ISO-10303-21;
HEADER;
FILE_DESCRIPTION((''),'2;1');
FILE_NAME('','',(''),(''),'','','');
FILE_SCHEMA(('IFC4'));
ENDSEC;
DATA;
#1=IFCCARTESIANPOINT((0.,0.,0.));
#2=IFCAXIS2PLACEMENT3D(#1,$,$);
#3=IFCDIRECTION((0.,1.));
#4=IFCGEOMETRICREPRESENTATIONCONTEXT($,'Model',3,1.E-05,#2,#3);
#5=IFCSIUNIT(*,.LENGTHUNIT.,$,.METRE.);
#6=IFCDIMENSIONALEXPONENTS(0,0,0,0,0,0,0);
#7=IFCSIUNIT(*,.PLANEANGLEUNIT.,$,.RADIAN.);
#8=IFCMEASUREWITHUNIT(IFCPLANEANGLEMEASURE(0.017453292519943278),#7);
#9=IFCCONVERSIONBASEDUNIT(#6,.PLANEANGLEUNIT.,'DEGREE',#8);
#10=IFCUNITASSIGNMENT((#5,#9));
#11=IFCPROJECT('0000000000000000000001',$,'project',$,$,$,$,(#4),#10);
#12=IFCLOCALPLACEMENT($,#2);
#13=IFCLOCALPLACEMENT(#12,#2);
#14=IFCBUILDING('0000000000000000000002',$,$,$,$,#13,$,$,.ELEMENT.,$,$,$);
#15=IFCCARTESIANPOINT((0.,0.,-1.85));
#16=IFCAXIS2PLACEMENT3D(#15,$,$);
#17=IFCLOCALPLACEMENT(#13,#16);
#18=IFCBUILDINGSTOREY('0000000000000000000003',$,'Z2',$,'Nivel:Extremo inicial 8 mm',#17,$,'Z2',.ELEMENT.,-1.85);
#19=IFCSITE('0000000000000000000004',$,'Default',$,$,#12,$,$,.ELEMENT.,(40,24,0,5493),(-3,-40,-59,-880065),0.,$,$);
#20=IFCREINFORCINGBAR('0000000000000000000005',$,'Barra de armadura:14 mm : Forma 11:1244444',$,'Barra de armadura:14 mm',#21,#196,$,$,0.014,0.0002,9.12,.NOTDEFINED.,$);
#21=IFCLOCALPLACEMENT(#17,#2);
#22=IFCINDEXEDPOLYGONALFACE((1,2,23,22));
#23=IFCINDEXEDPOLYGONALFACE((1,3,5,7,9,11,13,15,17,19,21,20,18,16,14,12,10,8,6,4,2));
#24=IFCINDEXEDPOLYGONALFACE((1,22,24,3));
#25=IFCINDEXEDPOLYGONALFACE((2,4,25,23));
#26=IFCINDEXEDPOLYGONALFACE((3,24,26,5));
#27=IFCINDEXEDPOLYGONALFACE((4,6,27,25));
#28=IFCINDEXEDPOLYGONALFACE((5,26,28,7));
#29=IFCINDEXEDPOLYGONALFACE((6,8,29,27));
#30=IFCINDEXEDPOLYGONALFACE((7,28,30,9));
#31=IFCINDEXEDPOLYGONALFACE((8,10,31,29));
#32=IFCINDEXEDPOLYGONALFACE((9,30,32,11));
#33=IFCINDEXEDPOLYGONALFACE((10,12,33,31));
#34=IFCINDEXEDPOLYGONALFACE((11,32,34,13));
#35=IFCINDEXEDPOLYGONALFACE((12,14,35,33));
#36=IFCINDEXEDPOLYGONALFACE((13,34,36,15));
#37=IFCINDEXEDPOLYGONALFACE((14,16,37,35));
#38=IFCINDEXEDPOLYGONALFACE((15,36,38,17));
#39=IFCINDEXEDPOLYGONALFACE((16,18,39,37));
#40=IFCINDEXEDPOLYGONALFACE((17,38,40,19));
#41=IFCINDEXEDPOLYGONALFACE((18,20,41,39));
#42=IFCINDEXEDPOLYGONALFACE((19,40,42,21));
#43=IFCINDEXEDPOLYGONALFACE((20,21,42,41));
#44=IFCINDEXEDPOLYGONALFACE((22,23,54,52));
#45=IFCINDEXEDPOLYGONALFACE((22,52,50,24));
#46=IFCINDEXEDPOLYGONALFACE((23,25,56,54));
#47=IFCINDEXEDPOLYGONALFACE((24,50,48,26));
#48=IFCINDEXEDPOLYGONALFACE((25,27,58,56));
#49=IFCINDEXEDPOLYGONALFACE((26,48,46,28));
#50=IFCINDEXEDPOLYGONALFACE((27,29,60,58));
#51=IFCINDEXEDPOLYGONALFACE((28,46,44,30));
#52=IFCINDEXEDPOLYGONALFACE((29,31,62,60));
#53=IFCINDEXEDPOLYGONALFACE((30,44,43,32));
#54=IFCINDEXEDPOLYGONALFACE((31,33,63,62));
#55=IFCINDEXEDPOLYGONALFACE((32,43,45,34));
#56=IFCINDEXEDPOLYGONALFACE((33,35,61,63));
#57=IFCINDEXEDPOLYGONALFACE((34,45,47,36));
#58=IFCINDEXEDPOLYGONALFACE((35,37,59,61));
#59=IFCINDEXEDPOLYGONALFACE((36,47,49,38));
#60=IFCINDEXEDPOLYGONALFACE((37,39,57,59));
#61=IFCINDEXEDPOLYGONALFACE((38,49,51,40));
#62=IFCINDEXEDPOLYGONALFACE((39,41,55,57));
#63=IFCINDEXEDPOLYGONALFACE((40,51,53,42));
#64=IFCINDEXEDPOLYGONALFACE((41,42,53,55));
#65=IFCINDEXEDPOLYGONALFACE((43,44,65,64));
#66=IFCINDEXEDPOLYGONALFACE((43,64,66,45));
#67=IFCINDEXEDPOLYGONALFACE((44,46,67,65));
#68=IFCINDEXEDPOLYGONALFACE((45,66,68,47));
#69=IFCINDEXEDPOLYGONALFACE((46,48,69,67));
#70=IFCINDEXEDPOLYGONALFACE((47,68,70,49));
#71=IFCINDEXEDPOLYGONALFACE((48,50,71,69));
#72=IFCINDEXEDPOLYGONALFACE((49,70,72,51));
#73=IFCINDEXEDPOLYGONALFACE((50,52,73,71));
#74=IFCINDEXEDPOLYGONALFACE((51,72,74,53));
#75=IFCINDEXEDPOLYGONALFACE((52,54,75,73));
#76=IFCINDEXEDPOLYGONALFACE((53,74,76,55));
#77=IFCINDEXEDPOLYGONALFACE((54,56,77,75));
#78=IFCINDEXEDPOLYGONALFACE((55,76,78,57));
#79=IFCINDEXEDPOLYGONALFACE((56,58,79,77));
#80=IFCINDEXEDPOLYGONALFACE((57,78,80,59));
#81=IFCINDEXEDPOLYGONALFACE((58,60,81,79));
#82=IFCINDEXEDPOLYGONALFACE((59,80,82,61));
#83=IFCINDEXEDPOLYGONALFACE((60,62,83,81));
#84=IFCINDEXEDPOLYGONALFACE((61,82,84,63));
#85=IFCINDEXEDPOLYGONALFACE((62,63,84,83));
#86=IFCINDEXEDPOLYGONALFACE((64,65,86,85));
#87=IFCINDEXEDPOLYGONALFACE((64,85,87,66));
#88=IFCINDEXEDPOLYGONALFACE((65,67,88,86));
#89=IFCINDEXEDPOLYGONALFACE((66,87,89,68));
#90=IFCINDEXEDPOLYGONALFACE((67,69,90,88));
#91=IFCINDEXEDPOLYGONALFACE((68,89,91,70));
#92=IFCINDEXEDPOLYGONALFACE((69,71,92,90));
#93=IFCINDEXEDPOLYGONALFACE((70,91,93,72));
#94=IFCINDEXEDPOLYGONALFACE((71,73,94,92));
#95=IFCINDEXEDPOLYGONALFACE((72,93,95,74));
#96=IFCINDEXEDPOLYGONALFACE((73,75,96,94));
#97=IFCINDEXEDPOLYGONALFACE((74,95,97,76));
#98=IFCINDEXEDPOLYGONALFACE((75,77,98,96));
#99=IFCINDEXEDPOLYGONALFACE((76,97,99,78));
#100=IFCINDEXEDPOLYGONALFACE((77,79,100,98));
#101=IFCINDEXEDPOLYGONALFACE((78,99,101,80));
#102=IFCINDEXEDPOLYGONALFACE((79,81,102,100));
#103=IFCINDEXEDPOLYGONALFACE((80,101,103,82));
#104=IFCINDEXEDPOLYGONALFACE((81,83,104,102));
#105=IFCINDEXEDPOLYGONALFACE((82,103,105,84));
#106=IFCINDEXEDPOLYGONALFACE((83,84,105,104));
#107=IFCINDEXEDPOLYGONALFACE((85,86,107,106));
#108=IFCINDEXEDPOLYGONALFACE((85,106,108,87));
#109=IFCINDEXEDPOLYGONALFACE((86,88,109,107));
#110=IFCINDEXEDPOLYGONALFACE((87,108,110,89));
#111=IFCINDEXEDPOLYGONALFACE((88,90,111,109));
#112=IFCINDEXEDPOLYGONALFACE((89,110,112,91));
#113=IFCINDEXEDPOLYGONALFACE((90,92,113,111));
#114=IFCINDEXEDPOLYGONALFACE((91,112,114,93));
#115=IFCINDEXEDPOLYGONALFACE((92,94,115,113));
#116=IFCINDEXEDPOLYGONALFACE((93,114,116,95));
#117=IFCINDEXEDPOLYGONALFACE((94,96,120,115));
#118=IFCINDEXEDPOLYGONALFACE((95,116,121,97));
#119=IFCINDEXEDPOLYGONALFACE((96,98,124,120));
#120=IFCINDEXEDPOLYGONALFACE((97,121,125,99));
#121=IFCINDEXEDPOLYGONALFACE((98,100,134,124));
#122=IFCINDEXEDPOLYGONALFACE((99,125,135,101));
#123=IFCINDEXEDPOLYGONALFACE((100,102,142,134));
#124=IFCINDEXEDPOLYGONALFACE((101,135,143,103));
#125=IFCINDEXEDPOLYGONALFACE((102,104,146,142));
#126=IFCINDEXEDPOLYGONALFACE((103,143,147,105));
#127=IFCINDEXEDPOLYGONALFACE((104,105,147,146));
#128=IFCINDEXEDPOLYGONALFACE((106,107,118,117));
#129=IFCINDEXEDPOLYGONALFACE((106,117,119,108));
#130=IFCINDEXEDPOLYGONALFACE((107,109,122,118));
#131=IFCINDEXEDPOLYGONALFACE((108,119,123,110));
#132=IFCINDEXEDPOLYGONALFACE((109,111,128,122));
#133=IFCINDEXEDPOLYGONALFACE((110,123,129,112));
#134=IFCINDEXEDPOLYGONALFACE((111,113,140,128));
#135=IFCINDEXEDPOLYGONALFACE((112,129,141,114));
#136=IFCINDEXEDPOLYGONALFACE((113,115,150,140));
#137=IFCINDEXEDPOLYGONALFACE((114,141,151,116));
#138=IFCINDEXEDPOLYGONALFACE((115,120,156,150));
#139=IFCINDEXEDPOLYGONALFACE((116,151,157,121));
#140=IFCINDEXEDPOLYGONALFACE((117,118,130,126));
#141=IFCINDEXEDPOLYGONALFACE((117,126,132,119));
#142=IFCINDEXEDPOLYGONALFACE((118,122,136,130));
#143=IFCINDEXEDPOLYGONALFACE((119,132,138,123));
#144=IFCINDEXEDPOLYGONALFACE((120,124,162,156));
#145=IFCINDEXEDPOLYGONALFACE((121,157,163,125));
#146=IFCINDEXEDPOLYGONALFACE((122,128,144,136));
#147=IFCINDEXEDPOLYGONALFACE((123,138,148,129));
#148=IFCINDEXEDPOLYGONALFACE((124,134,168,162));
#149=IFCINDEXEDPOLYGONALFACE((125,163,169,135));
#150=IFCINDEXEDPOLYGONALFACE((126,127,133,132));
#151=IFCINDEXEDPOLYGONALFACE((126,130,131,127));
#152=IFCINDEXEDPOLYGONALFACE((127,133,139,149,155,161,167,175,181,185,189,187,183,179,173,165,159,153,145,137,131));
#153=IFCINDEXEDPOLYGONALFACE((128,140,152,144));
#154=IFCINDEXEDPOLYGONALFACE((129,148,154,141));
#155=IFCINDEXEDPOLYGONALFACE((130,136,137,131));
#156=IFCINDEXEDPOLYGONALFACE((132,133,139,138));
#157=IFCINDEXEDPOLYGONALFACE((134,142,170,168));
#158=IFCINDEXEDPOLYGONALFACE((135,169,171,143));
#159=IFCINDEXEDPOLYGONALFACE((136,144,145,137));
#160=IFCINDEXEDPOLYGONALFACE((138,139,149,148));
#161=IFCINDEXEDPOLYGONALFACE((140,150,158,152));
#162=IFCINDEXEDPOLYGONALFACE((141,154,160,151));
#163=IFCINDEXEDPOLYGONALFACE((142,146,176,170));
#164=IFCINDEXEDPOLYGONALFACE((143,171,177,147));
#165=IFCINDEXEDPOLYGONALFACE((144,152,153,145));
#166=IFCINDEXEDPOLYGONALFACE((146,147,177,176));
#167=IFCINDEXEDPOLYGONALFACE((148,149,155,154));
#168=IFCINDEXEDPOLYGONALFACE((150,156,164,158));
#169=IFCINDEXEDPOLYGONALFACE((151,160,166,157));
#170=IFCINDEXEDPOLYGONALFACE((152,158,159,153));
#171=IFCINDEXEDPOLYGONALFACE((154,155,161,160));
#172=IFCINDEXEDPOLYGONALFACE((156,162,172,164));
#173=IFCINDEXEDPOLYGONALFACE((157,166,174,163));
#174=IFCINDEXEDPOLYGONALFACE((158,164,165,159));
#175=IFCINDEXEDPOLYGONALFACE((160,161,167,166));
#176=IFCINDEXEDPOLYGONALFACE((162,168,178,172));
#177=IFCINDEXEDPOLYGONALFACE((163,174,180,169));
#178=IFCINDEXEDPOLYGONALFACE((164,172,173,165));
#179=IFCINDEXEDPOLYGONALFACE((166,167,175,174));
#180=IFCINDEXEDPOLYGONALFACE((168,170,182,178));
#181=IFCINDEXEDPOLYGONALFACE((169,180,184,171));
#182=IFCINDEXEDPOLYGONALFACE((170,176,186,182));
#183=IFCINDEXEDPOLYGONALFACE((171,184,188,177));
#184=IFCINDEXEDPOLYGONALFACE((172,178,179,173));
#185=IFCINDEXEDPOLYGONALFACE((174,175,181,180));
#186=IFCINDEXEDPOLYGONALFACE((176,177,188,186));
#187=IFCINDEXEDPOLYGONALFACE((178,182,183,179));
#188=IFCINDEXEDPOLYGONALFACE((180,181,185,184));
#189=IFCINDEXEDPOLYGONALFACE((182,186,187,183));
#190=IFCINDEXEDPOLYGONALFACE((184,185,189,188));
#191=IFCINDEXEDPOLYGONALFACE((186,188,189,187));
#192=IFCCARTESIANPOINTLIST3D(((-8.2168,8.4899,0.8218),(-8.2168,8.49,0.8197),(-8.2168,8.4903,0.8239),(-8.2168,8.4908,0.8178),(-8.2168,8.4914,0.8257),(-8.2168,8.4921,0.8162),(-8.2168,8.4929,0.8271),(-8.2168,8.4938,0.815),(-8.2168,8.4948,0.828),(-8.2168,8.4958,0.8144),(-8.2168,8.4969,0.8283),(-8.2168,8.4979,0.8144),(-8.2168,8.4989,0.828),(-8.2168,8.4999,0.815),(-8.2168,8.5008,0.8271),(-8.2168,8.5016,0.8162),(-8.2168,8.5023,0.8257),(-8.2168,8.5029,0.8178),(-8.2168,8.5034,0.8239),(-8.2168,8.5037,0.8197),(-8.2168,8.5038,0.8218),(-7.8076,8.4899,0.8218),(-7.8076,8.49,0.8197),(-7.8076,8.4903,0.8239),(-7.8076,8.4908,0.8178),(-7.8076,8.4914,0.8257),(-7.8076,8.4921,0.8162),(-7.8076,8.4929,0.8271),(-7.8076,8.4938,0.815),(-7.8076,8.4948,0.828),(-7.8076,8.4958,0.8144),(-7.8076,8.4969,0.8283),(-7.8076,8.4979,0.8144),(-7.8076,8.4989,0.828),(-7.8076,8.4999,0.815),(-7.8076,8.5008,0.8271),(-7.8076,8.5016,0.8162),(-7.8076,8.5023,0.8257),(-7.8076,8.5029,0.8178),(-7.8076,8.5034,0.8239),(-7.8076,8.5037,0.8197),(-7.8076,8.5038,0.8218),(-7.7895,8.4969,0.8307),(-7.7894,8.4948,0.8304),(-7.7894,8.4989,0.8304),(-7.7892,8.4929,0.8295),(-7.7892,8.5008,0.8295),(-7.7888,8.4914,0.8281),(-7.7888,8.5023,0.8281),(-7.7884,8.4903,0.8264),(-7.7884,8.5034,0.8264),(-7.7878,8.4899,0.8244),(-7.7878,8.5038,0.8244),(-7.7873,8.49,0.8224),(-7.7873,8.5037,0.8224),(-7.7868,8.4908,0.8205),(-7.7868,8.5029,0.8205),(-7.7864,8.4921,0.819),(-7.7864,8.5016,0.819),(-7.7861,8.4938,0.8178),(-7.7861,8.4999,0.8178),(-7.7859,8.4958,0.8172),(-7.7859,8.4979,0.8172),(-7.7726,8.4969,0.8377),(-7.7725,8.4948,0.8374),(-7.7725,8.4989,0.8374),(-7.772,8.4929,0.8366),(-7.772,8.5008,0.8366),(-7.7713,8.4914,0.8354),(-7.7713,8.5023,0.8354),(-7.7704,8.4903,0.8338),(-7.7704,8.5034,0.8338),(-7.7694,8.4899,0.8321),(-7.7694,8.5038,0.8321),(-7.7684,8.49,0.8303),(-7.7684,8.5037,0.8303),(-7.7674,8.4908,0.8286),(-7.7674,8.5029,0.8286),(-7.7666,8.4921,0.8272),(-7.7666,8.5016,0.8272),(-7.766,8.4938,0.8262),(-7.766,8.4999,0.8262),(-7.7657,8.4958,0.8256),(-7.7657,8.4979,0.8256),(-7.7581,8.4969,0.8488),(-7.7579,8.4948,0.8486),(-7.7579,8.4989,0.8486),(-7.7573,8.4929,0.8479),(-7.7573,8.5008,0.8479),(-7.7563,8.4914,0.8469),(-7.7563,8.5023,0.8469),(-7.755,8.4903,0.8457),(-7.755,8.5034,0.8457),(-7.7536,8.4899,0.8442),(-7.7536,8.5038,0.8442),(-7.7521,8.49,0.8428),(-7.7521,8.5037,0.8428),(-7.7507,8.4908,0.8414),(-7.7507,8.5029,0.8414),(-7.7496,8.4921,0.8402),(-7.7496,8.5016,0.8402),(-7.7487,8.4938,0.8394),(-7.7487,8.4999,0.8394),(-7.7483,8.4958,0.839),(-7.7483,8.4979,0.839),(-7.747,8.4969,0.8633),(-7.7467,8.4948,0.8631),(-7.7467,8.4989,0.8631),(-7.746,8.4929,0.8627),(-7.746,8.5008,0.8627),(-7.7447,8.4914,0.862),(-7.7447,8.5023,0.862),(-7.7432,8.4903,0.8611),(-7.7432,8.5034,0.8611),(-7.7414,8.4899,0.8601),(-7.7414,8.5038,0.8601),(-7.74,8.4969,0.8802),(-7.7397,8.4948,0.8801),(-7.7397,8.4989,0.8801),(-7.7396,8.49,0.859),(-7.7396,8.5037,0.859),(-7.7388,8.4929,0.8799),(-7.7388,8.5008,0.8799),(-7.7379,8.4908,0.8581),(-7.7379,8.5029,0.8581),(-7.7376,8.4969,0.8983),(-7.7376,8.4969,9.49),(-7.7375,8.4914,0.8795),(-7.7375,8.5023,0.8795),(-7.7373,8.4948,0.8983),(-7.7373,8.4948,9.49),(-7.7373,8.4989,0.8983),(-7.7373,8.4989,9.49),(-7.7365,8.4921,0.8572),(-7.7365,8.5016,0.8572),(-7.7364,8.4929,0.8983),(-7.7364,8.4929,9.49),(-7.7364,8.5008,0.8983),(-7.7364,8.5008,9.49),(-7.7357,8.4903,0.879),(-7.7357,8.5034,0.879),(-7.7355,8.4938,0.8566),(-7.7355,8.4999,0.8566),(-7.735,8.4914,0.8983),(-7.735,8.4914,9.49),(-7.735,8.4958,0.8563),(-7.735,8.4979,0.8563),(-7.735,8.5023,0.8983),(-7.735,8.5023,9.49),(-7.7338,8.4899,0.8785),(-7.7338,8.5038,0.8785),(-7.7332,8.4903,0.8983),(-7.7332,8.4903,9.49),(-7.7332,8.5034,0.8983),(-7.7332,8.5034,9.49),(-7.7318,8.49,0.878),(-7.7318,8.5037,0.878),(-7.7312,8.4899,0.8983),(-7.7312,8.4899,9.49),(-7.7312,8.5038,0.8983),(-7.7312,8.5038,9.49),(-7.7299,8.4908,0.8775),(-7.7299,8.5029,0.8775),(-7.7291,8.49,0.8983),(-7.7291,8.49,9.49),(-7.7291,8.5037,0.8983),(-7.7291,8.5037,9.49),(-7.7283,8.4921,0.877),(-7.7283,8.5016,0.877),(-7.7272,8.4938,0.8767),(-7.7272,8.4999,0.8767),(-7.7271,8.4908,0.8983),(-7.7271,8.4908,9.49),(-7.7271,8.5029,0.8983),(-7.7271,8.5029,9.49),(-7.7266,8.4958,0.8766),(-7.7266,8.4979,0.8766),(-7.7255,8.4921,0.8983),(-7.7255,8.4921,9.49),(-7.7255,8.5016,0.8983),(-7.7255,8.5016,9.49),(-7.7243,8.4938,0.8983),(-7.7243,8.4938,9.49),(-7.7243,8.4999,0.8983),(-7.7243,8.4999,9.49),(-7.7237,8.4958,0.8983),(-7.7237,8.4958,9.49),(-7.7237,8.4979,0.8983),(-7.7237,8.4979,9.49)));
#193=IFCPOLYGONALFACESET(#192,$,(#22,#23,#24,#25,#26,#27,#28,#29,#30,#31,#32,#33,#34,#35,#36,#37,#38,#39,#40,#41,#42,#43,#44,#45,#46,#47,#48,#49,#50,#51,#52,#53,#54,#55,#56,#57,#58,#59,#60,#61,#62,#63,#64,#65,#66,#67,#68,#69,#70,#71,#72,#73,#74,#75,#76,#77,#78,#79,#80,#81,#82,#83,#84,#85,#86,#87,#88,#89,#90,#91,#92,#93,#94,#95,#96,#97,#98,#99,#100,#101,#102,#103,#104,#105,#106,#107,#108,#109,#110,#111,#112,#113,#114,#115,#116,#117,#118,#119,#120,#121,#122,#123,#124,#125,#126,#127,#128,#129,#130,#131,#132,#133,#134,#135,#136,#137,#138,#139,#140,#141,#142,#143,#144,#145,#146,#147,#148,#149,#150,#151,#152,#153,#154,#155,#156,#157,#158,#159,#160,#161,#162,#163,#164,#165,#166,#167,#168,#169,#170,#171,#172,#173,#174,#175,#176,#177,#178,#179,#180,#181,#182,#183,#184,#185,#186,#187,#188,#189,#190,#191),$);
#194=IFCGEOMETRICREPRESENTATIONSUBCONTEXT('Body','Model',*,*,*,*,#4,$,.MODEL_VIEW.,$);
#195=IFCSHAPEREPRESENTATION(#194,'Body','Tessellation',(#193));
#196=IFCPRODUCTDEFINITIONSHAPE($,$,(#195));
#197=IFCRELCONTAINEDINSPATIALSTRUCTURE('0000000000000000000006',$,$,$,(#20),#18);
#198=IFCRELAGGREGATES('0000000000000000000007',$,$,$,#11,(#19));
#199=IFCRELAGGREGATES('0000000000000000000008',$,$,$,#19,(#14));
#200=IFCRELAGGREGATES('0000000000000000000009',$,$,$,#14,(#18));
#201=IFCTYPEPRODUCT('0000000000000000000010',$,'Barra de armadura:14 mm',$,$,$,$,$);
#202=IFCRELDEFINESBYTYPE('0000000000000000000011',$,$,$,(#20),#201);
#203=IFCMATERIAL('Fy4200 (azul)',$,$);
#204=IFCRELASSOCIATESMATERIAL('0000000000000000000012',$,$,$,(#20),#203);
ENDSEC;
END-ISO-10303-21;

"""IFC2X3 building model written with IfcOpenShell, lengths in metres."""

from ifc_helpers import new_model, entity, si_unit, converted_unit, direction, frame, origin, place, context, subcontext, project, spatial, material, type_object, element, save


model = new_model("IFC2X3")

# Units and contexts
model_context = context("Model", 3, precision=1e-05, world=origin(), true_north=direction((0.0, 1.0)))
body_context = subcontext(model_context, "Body", "Model", "MODEL_VIEW")
ifc_project = project(units=[si_unit("LENGTHUNIT", "METRE"), converted_unit("PLANEANGLEUNIT", "DEGREE", entity("IfcPlaneAngleMeasure", 0.017453292519943278), si_unit("PLANEANGLEUNIT", "RADIAN"), dimensions=[0, 0, 0, 0, 0, 0, 0])], contexts=[model_context])

# Site, building, storey
site_placement = place(None, origin())
site = spatial("IfcSite", under=ifc_project, at=site_placement, Name="Default", CompositionType="ELEMENT", RefLatitude=(40, 24, 0, 5493), RefLongitude=(-3, -40, -59, -880065), RefElevation=0.0)
building_placement = place(site_placement, origin())
building = spatial("IfcBuilding", under=site, at=building_placement, CompositionType="ELEMENT")
storey_placement = place(building_placement, frame((0.0, 0.0, -1.85)))
storey = spatial("IfcBuildingStorey", under=building, at=storey_placement, Name="Z2", ObjectType="Nivel:Extremo inicial 8 mm", LongName="Z2", CompositionType="ELEMENT", Elevation=-1.85)

# Reinforcing bar
ifc_material_1 = material(Name="Fy4200 (azul)")
type_product_1 = type_object("IfcTypeProduct", Name="Barra de armadura:14 mm")
reinforcing_bar_1_placement = place(storey_placement, origin())
element("IfcReinforcingBar", 1, at=reinforcing_bar_1_placement, inside=storey, type_object=type_product_1, material=ifc_material_1, Name="Barra de armadura:14 mm : Forma 11:1244444", ObjectType="Barra de armadura:14 mm", BarLength=9.12, BarRole="NOTDEFINED", CrossSectionArea=0.0002, NominalDiameter=0.014, context=body_context, shape_type="AdvancedSweptSolid", body=[
    entity("IfcSweptDiskSolid", entity("IfcCompositeCurve", [entity("IfcCompositeCurveSegment", "CONTINUOUS", True, entity("IfcPolyline", [entity("IfcCartesianPoint", [-7.7306, 8.4969, 9.49]), entity("IfcCartesianPoint", [-7.7306, 8.4969, 0.8983])])), entity("IfcCompositeCurveSegment", "CONTINUOUS", True, entity("IfcTrimmedCurve", entity("IfcCircle", entity("IfcAxis2Placement3D", entity("IfcCartesianPoint", [-7.8076, 8.4969, 0.8983]), entity("IfcDirection", [0.0, 1.0, 0.0]), entity("IfcDirection", [0.0, 0.0, -1.0])), 0.077), [entity("IfcParameterValue", 270.0)], [entity("IfcParameterValue", 360.0)], True, "PARAMETER")), entity("IfcCompositeCurveSegment", "CONTINUOUS", True, entity("IfcPolyline", [entity("IfcCartesianPoint", [-7.8076, 8.4969, 0.8213]), entity("IfcCartesianPoint", [-8.2168, 8.4969, 0.8213])]))], False), 0.007, None, 0.0, 92.0),
])

save(model, "model.ifc")
